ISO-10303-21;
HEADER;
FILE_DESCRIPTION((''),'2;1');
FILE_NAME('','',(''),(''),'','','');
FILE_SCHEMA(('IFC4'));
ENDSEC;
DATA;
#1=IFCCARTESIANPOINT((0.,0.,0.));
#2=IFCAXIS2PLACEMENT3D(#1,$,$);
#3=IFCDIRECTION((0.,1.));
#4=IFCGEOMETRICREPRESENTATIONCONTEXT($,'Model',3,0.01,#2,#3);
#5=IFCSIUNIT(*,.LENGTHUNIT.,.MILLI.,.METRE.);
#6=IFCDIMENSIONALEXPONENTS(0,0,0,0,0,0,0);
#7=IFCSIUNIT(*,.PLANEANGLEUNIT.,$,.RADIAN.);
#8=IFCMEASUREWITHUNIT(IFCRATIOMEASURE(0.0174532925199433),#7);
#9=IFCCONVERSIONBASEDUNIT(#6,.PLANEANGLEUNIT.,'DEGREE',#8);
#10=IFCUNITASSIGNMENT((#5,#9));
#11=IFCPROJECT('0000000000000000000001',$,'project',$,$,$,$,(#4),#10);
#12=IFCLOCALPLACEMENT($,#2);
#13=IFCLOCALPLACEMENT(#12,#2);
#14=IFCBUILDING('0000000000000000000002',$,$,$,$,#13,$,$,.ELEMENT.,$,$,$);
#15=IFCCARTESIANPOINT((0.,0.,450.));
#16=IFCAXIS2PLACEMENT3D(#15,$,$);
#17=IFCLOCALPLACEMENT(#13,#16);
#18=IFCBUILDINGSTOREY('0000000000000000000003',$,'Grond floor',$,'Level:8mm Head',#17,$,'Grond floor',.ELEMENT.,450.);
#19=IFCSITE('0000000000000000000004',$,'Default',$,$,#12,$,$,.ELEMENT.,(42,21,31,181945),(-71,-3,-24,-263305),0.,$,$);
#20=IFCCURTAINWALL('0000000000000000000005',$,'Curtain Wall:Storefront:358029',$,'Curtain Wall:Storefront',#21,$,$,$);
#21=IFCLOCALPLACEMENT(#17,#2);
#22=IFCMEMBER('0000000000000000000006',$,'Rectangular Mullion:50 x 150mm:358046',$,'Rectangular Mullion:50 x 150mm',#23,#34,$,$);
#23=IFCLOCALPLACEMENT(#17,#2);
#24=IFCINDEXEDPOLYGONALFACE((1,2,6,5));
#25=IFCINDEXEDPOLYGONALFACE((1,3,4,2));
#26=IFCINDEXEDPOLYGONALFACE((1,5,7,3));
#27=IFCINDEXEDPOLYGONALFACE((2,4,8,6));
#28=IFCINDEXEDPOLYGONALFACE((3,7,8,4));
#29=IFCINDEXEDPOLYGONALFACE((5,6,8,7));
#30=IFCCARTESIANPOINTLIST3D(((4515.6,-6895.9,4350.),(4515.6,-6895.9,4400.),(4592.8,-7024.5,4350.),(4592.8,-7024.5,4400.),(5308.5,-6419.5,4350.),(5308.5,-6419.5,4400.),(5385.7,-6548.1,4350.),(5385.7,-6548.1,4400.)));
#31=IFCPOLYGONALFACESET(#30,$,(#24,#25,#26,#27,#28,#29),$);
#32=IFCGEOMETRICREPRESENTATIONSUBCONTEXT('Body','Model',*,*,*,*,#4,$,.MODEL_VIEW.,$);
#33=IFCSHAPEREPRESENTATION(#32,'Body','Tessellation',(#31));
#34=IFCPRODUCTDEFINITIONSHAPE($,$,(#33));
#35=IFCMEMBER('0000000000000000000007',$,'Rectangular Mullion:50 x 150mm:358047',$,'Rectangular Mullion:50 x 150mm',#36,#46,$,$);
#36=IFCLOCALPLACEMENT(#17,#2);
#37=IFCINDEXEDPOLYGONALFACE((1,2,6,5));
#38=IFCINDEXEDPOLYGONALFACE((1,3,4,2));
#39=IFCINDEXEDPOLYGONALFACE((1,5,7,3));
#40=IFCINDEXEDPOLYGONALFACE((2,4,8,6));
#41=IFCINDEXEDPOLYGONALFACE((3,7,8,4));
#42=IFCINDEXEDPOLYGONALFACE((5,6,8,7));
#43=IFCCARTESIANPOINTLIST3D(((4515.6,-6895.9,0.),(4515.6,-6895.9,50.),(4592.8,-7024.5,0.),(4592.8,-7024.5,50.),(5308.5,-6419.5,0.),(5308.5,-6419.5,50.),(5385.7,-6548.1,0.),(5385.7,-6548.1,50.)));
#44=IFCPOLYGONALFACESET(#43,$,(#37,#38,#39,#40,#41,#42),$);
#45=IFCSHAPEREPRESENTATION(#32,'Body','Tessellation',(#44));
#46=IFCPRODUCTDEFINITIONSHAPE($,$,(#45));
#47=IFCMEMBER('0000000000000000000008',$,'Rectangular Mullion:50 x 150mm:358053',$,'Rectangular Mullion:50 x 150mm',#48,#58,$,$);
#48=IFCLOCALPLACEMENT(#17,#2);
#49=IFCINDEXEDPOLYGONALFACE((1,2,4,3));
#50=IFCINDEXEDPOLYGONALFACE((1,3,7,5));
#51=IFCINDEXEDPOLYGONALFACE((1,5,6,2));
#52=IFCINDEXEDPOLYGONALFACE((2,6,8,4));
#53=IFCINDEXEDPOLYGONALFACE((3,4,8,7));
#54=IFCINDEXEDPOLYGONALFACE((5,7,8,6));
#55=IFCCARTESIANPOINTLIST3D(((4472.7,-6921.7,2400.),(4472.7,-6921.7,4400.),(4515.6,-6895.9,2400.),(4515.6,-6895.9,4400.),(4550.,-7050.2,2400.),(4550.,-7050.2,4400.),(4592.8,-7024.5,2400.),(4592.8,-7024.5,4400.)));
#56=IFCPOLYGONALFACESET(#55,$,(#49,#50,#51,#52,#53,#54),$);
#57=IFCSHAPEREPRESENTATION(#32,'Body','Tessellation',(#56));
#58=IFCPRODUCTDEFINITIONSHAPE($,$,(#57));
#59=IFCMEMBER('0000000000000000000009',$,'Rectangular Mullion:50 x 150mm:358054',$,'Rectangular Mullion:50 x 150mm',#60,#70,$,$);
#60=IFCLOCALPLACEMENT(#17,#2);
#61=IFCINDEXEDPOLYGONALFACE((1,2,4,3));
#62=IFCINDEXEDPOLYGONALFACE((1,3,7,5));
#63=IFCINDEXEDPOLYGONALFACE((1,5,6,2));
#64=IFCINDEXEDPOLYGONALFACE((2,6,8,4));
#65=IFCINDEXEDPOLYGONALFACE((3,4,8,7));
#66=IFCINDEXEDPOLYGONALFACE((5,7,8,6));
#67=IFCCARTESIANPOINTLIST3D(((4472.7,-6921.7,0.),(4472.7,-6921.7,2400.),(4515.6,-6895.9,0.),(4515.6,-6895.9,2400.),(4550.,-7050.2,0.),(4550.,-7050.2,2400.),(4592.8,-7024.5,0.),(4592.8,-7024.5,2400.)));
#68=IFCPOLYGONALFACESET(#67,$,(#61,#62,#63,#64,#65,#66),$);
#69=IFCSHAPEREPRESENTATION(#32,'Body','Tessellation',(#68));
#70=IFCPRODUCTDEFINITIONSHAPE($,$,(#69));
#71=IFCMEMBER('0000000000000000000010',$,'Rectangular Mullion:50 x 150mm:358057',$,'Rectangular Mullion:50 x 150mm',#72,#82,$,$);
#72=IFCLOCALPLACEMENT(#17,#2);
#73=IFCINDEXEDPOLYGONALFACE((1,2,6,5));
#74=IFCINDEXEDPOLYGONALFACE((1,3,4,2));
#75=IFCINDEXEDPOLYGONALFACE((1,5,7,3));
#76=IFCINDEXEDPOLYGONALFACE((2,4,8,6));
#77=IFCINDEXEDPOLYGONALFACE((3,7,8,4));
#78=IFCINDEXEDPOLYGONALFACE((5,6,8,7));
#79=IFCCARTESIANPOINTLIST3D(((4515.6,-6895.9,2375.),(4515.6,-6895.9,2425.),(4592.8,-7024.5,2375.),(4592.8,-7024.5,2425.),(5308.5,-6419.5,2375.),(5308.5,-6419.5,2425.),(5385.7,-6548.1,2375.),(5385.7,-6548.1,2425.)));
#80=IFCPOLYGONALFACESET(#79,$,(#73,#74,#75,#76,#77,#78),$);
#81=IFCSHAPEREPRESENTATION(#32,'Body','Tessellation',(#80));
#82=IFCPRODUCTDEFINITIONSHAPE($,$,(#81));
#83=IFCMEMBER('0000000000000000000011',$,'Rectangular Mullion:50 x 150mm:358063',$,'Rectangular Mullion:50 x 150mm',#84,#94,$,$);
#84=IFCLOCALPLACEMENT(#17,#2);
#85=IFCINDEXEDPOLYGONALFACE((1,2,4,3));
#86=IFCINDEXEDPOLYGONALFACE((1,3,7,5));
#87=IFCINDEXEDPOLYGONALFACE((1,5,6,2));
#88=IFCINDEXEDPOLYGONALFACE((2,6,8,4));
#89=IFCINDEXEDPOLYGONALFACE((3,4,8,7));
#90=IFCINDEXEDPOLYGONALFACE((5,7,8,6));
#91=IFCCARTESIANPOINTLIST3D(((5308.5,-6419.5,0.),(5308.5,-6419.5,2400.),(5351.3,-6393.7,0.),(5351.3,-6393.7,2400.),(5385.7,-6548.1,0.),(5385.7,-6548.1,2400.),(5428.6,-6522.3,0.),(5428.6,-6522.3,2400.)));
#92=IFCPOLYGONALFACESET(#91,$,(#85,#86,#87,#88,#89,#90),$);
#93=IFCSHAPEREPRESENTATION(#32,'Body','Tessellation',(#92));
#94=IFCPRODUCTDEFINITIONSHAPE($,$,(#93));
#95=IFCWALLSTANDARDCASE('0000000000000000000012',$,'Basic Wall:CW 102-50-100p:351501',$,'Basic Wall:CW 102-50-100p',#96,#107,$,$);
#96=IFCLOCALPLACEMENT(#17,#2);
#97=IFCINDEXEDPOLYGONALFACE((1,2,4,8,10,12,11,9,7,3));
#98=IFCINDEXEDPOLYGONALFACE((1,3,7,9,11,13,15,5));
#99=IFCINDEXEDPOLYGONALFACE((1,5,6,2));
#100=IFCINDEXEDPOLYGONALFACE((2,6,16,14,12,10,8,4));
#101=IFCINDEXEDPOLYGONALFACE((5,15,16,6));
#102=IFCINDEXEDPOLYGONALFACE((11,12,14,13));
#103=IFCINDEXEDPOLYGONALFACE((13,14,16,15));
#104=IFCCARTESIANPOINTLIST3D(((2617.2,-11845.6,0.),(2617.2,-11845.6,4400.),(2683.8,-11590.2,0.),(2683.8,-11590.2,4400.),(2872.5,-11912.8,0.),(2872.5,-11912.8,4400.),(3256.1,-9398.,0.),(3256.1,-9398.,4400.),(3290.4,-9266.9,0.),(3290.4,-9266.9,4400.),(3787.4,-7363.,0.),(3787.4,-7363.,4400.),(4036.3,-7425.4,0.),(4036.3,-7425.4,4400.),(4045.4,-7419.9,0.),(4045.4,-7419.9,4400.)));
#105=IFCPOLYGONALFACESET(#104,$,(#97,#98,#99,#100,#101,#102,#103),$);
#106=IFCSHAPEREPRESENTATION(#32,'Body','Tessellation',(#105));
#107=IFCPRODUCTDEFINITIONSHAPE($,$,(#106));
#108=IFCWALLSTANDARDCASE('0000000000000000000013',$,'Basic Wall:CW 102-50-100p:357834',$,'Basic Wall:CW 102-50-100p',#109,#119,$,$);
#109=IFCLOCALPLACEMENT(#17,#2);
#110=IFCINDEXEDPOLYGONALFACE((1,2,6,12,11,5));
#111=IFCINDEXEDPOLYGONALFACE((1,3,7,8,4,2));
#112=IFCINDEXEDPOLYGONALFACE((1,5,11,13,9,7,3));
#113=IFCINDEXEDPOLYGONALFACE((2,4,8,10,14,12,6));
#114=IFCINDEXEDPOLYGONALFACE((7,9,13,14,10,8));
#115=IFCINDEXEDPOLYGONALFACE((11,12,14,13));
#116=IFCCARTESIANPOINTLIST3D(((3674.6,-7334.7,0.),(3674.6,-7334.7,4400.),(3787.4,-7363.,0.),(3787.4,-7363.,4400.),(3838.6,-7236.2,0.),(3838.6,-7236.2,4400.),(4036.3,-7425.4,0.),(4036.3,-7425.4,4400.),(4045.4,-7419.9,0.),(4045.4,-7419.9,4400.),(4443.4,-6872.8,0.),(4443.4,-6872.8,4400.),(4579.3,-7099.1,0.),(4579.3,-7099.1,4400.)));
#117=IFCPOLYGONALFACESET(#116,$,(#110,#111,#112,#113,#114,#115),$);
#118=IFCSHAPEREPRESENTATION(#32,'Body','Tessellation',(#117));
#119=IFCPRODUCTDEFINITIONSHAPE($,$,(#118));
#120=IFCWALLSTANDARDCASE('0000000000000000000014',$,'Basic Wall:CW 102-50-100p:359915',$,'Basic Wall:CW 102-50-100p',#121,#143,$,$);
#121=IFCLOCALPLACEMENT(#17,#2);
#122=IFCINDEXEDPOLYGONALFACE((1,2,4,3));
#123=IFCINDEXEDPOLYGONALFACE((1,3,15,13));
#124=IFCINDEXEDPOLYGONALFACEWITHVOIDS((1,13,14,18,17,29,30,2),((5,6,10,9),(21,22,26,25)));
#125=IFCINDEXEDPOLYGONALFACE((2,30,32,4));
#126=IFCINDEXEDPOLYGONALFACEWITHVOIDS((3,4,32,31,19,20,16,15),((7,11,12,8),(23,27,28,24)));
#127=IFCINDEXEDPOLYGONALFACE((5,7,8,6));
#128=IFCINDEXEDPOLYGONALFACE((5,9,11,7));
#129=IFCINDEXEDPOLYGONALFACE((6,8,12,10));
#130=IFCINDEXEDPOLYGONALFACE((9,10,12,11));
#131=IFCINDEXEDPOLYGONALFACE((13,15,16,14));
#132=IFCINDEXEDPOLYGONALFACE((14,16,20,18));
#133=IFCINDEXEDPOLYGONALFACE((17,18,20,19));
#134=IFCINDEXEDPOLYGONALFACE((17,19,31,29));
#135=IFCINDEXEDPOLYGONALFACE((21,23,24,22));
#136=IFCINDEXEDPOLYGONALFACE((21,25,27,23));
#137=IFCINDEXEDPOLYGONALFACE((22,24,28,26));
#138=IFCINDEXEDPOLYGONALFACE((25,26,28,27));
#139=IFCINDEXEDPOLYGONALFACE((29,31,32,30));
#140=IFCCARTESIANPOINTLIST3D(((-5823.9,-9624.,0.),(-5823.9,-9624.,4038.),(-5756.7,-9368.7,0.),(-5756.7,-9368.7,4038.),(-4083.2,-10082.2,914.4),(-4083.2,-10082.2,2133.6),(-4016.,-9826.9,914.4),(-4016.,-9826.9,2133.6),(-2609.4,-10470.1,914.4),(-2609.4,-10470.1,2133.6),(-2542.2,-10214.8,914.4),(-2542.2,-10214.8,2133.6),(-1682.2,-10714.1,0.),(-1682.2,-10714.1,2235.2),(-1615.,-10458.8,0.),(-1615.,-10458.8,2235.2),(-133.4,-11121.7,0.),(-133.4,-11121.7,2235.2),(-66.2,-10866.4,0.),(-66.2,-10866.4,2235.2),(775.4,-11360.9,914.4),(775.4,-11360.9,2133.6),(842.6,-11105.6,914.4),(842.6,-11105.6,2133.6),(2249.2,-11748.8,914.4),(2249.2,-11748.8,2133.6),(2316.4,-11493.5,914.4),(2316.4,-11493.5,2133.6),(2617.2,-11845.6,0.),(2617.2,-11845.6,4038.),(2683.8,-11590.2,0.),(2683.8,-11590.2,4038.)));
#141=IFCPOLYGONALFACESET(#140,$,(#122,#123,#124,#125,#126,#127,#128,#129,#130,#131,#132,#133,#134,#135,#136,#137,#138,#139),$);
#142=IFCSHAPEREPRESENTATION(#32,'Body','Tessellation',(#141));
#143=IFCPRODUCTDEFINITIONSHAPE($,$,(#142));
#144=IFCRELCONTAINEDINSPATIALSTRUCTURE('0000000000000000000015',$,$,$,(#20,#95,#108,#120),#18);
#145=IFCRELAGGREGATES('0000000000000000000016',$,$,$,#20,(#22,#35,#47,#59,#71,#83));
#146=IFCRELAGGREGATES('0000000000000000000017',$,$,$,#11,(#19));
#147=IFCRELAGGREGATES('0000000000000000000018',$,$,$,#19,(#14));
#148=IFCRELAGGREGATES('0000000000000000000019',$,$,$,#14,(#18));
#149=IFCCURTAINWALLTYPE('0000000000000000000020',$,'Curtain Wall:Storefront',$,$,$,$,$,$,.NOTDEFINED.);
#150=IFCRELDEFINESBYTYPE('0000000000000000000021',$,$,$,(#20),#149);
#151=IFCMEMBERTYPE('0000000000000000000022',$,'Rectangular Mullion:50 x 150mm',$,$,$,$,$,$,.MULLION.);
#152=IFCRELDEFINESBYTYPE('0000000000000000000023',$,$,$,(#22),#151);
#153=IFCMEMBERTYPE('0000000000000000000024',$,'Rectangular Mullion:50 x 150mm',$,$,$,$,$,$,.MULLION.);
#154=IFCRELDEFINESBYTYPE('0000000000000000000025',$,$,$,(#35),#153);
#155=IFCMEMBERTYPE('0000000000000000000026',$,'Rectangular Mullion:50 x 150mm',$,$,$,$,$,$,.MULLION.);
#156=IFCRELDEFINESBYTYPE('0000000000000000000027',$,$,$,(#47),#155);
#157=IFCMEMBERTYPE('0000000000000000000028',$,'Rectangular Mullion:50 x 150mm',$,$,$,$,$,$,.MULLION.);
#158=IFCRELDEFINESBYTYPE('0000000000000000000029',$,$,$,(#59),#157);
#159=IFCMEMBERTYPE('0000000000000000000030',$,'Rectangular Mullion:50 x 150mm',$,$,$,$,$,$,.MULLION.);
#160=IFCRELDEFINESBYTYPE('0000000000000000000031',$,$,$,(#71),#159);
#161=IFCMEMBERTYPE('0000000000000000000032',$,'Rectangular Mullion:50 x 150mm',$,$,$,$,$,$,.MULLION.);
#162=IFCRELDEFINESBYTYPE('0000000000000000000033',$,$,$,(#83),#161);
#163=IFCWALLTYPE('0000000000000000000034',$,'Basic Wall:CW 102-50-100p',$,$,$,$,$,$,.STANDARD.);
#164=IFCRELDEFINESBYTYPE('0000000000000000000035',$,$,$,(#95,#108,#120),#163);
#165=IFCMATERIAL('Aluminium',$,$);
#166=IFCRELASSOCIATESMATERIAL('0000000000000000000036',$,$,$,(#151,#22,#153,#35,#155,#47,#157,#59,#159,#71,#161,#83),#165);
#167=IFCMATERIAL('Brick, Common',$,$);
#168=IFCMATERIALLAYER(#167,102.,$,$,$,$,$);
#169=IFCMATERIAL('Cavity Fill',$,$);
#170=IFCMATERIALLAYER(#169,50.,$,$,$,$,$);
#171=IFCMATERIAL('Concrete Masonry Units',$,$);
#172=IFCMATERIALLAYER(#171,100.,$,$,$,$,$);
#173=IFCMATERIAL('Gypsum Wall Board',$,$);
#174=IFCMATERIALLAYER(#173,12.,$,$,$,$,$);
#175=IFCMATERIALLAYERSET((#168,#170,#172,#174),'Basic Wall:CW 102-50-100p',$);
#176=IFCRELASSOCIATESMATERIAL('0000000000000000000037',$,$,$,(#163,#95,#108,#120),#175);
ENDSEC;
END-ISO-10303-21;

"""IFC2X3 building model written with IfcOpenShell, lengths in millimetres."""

from ifc_helpers import new_model, entity, si_unit, converted_unit, direction, frame, frame_2d, origin, origin_2d_with_axis, place, context, subcontext, project, spatial, polyline, rectangle, outline, extrude, source, transform, mapped, material, layer, layer_set, layer_usage, type_object, type_shapes, element, aggregate, save


model = new_model("IFC2X3")

# Units and contexts
model_context = context("Model", 3, precision=0.01, world=origin(), true_north=direction((0.0, 1.0)))
body_context = subcontext(model_context, "Body", "Model", "MODEL_VIEW")
ifc_project = project(units=[si_unit("LENGTHUNIT", "METRE", prefix="MILLI"), converted_unit("PLANEANGLEUNIT", "DEGREE", entity("IfcRatioMeasure", 0.0174532925199433), si_unit("PLANEANGLEUNIT", "RADIAN"), dimensions=[0, 0, 0, 0, 0, 0, 0])], contexts=[model_context])

# Site, building, storey
site_placement = place(None, origin())
site = spatial("IfcSite", under=ifc_project, at=site_placement, Name="Default", CompositionType="ELEMENT", RefLatitude=(42, 21, 31, 181945), RefLongitude=(-71, -3, -24, -263305), RefElevation=0.0)
building_placement = place(site_placement, origin())
building = spatial("IfcBuilding", under=site, at=building_placement, CompositionType="ELEMENT")
storey_placement = place(building_placement, frame((0.0, 0.0, 450.0)))
storey = spatial("IfcBuildingStorey", under=building, at=storey_placement, Name="Grond floor", ObjectType="Level:8mm Head", LongName="Grond floor", CompositionType="ELEMENT", Elevation=450.0)

# Curtain wall, members
curtain_wall_type = type_object("IfcCurtainWallType", Name="Curtain Wall:Storefront", PredefinedType="NOTDEFINED")
curtain_wall_placement = place(storey_placement, frame((0.0, 0.0, -450.0)))
curtain_wall = element("IfcCurtainWall", 1, at=curtain_wall_placement, inside=storey, type_object=curtain_wall_type, Name="Curtain Wall:Storefront:358029", ObjectType="Curtain Wall:Storefront")
ifc_material_1 = material(Name="Aluminium")
member_type_1 = type_object("IfcMemberType", Name="Rectangular Mullion:50 x 150mm", PredefinedType="MULLION", material=ifc_material_1)
shared_shape_1 = source(origin(), body_context, "Body", "SweptSolid", [
    extrude(rectangle(XDim=150.0, YDim=50.0, at=origin_2d_with_axis()), frame((-25.0, 0.0, -925.0), z_axis=(0.0, 0.0, 1.0), x_axis=(0.0, -1.0, 0.0)), (0.0, 0.0, 1.0), 925.0),
])
type_shapes(member_type_1, [shared_shape_1])
member_1_placement = place(storey_placement, frame((5347.1, -6483.8, 4400.0), z_axis=(0.857167, 0.515038, 0.0), x_axis=(0.0, 0.0, 1.0)))
member_1 = element("IfcMember", 2, at=member_1_placement, type_object=member_type_1, material=ifc_material_1, Name="Rectangular Mullion:50 x 150mm:358046", ObjectType="Rectangular Mullion:50 x 150mm", context=body_context, shape_type="MappedRepresentation", body=[
    mapped(shared_shape_1, transform((0.0, 0.0, 0.0), scale=1.0)),
])
member_type_2 = type_object("IfcMemberType", Name="Rectangular Mullion:50 x 150mm", PredefinedType="MULLION", material=ifc_material_1)
shared_shape_2 = source(origin(), body_context, "Body", "SweptSolid", [
    extrude(rectangle(XDim=150.0, YDim=50.0, at=origin_2d_with_axis()), frame((-25.0, 0.0, -925.0), z_axis=(0.0, 0.0, 1.0), x_axis=(0.0, -1.0, 0.0)), (0.0, 0.0, 1.0), 925.0),
])
type_shapes(member_type_2, [shared_shape_2])
member_2_placement = place(storey_placement, frame((4554.2, -6960.2, 0.0), z_axis=(-0.857167, -0.515038, 0.0), x_axis=(0.0, 0.0, -1.0)))
member_2 = element("IfcMember", 3, at=member_2_placement, type_object=member_type_2, material=ifc_material_1, Name="Rectangular Mullion:50 x 150mm:358047", ObjectType="Rectangular Mullion:50 x 150mm", context=body_context, shape_type="MappedRepresentation", body=[
    mapped(shared_shape_2, transform((0.0, 0.0, 0.0), scale=1.0)),
])
member_type_3 = type_object("IfcMemberType", Name="Rectangular Mullion:50 x 150mm", PredefinedType="MULLION", material=ifc_material_1)
shared_shape_3 = source(origin(), body_context, "Body", "SweptSolid", [
    extrude(rectangle(XDim=150.0, YDim=50.0, at=origin_2d_with_axis()), frame((-25.0, 0.0, -2000.0), z_axis=(0.0, 0.0, 1.0), x_axis=(0.0, -1.0, 0.0)), (0.0, 0.0, 1.0), 2000.0),
])
type_shapes(member_type_3, [shared_shape_3])
member_3_placement = place(storey_placement, frame((4511.3, -6985.9, 4400.0), z_axis=(0.0, 0.0, 1.0), x_axis=(-0.857167, -0.515038, 0.0)))
member_3 = element("IfcMember", 4, at=member_3_placement, type_object=member_type_3, material=ifc_material_1, Name="Rectangular Mullion:50 x 150mm:358053", ObjectType="Rectangular Mullion:50 x 150mm", context=body_context, shape_type="MappedRepresentation", body=[
    mapped(shared_shape_3, transform((0.0, 0.0, 0.0), scale=1.0)),
])
member_type_4 = type_object("IfcMemberType", Name="Rectangular Mullion:50 x 150mm", PredefinedType="MULLION", material=ifc_material_1)
shared_shape_4 = source(origin(), body_context, "Body", "SweptSolid", [
    extrude(rectangle(XDim=150.0, YDim=50.0, at=origin_2d_with_axis()), frame((-25.0, 0.0, -2400.0), z_axis=(0.0, 0.0, 1.0), x_axis=(0.0, -1.0, 0.0)), (0.0, 0.0, 1.0), 2400.0),
])
type_shapes(member_type_4, [shared_shape_4])
member_4_placement = place(storey_placement, frame((4511.3, -6985.9, 2400.0), z_axis=(0.0, 0.0, 1.0), x_axis=(-0.857167, -0.515038, 0.0)))
member_4 = element("IfcMember", 5, at=member_4_placement, type_object=member_type_4, material=ifc_material_1, Name="Rectangular Mullion:50 x 150mm:358054", ObjectType="Rectangular Mullion:50 x 150mm", context=body_context, shape_type="MappedRepresentation", body=[
    mapped(shared_shape_4, transform((0.0, 0.0, 0.0), scale=1.0)),
])
member_type_5 = type_object("IfcMemberType", Name="Rectangular Mullion:50 x 150mm", PredefinedType="MULLION", material=ifc_material_1)
shared_shape_5 = source(origin(), body_context, "Body", "SweptSolid", [
    extrude(rectangle(XDim=150.0, YDim=50.0, at=origin_2d_with_axis()), frame((0.0, 0.0, -925.0), z_axis=(0.0, 0.0, 1.0), x_axis=(0.0, -1.0, 0.0)), (0.0, 0.0, 1.0), 925.0),
])
type_shapes(member_type_5, [shared_shape_5])
member_5_placement = place(storey_placement, frame((5347.1, -6483.8, 2400.0), z_axis=(0.857167, 0.515038, 0.0), x_axis=(0.0, 0.0, 1.0)))
member_5 = element("IfcMember", 6, at=member_5_placement, type_object=member_type_5, material=ifc_material_1, Name="Rectangular Mullion:50 x 150mm:358057", ObjectType="Rectangular Mullion:50 x 150mm", context=body_context, shape_type="MappedRepresentation", body=[
    mapped(shared_shape_5, transform((0.0, 0.0, 0.0), scale=1.0)),
])
member_type_6 = type_object("IfcMemberType", Name="Rectangular Mullion:50 x 150mm", PredefinedType="MULLION", material=ifc_material_1)
shared_shape_6 = source(origin(), body_context, "Body", "SweptSolid", [
    extrude(rectangle(XDim=150.0, YDim=50.0, at=origin_2d_with_axis()), frame((0.0, 0.0, -2400.0), z_axis=(0.0, 0.0, 1.0), x_axis=(0.0, -1.0, 0.0)), (0.0, 0.0, 1.0), 2400.0),
])
type_shapes(member_type_6, [shared_shape_6])
member_6_placement = place(storey_placement, frame((5368.5, -6470.9, 0.0), z_axis=(0.0, 0.0, -1.0), x_axis=(0.857167, 0.515038, 0.0)))
member_6 = element("IfcMember", 7, at=member_6_placement, type_object=member_type_6, material=ifc_material_1, Name="Rectangular Mullion:50 x 150mm:358063", ObjectType="Rectangular Mullion:50 x 150mm", context=body_context, shape_type="MappedRepresentation", body=[
    mapped(shared_shape_6, transform((0.0, 0.0, 0.0), scale=1.0)),
])
aggregate(curtain_wall, [member_1, member_2, member_3, member_4, member_5, member_6])

# Walls
ifc_material_2 = material(Name="Brick, Common")
ifc_layer_1 = layer(ifc_material_2, 102.0)
ifc_material_3 = material(Name="Cavity Fill")
ifc_layer_2 = layer(ifc_material_3, 50.0)
ifc_material_4 = material(Name="Concrete Masonry Units")
ifc_layer_3 = layer(ifc_material_4, 100.0)
ifc_material_5 = material(Name="Gypsum Wall Board")
ifc_layer_4 = layer(ifc_material_5, 12.0)
ifc_layer_set_1 = layer_set([ifc_layer_1, ifc_layer_2, ifc_layer_3, ifc_layer_4], Name="Basic Wall:CW 102-50-100p")
ifc_layer_usage_1 = layer_usage(ifc_layer_set_1, "AXIS2", "NEGATIVE", 132.0)
wall_type_1 = type_object("IfcWallType", Name="Basic Wall:CW 102-50-100p", PredefinedType="STANDARD", material=ifc_layer_set_1)
wall_1_placement = place(storey_placement, frame((3917.7, -7386.6, 0.0), z_axis=(0.0, 0.0, 1.0), x_axis=(-0.252594, -0.967572, 0.0)))
element("IfcWallStandardCase", 8, at=wall_1_placement, inside=storey, type_object=wall_type_1, material=ifc_layer_usage_1, Name="Basic Wall:CW 102-50-100p:351501", ObjectType="Basic Wall:CW 102-50-100p", context=body_context, shape_type="SweptSolid", body=[
    extrude(outline(polyline([(4643.0, -132.0), (4643.5, 132.0), (0.0, 132.0), (7.6, 124.6), (10.1, -132.0), (1977.8, -132.0), (2113.3, -132.0), (4379.0, -132.0), (4643.0, -132.0)])), origin(), (0.0, 0.0, 1.0), 4400.0),
])
ifc_layer_usage_2 = layer_usage(ifc_layer_set_1, "AXIS2", "NEGATIVE", 132.0)
wall_2_placement = place(storey_placement, frame((4511.3, -6985.9, 0.0), z_axis=(0.0, 0.0, 1.0), x_axis=(-0.857167, -0.515038, 0.0)))
element("IfcWallStandardCase", 9, at=wall_2_placement, inside=storey, type_object=wall_type_1, material=ifc_layer_usage_2, Name="Basic Wall:CW 102-50-100p:357834", ObjectType="Basic Wall:CW 102-50-100p", context=body_context, shape_type="SweptSolid", body=[
    extrude(outline(polyline([(896.9, -132.0), (814.7, -49.7), (633.5, 132.0), (622.9, 132.0), (0.0, 132.0), (0.0, -132.0), (705.5, -132.0), (896.9, -132.0)])), origin(), (0.0, 0.0, 1.0), 4400.0),
])

# Wall, openings
ifc_layer_usage_3 = layer_usage(ifc_layer_set_1, "AXIS2", "NEGATIVE", 132.0)
wall_3_placement = place(storey_placement, frame((2650.8, -11718.0, 0.0), z_axis=(0.0, 0.0, 1.0), x_axis=(-0.967067, 0.25452, 0.0)))
wall_3 = element("IfcWallStandardCase", 10, at=wall_3_placement, inside=storey, type_object=wall_type_1, material=ifc_layer_usage_3, Name="Basic Wall:CW 102-50-100p:359915", ObjectType="Basic Wall:CW 102-50-100p", context=body_context, shape_type="SweptSolid", body=[
    extrude(outline(polyline([(0.5, -132.0), (8728.5, -132.0), (8728.5, 132.0), (0.0, 132.0), (0.5, -132.0)])), origin(), (0.0, 0.0, 1.0), 4038.0),
])
opening_1_placement = place(wall_3_placement, frame((2844.2, -132.0, 0.0)))
element("IfcOpeningElement", 11, at=opening_1_placement, cuts=wall_3, ObjectType="Opening", context=body_context, shape_type="SweptSolid", body=[
    extrude(rectangle(XDim=2235.2, YDim=1601.6, at=frame_2d((1117.6, 800.8), x_axis=(1.0, 0.0))), frame((0.0, 0.0, 0.0), z_axis=(0.0, 1.0, 0.0), x_axis=(0.0, 0.0, 1.0)), (0.0, 0.0, 1.0), 264.0),
])
opening_2_placement = place(wall_3_placement, frame((6928.5, 132.0, 914.4)))
element("IfcOpeningElement", 12, at=opening_2_placement, cuts=wall_3, ObjectType="Opening", context=body_context, shape_type="SweptSolid", body=[
    extrude(rectangle(XDim=1219.2, YDim=1524.0, at=frame_2d((609.6, 762.0), x_axis=(-1.0, 0.0))), frame((0.0, 0.0, 0.0), z_axis=(0.0, -1.0, 0.0), x_axis=(0.0, 0.0, 1.0)), (0.0, 0.0, 1.0), 264.0),
])
opening_3_placement = place(wall_3_placement, frame((1904.5, 132.0, 914.4)))
element("IfcOpeningElement", 13, at=opening_3_placement, cuts=wall_3, ObjectType="Opening", context=body_context, shape_type="SweptSolid", body=[
    extrude(rectangle(XDim=1219.2, YDim=1524.0, at=frame_2d((609.6, 762.0), x_axis=(-1.0, 0.0))), frame((0.0, 0.0, 0.0), z_axis=(0.0, -1.0, 0.0), x_axis=(0.0, 0.0, 1.0)), (0.0, 0.0, 1.0), 264.0),
])

save(model, "model.ifc")
